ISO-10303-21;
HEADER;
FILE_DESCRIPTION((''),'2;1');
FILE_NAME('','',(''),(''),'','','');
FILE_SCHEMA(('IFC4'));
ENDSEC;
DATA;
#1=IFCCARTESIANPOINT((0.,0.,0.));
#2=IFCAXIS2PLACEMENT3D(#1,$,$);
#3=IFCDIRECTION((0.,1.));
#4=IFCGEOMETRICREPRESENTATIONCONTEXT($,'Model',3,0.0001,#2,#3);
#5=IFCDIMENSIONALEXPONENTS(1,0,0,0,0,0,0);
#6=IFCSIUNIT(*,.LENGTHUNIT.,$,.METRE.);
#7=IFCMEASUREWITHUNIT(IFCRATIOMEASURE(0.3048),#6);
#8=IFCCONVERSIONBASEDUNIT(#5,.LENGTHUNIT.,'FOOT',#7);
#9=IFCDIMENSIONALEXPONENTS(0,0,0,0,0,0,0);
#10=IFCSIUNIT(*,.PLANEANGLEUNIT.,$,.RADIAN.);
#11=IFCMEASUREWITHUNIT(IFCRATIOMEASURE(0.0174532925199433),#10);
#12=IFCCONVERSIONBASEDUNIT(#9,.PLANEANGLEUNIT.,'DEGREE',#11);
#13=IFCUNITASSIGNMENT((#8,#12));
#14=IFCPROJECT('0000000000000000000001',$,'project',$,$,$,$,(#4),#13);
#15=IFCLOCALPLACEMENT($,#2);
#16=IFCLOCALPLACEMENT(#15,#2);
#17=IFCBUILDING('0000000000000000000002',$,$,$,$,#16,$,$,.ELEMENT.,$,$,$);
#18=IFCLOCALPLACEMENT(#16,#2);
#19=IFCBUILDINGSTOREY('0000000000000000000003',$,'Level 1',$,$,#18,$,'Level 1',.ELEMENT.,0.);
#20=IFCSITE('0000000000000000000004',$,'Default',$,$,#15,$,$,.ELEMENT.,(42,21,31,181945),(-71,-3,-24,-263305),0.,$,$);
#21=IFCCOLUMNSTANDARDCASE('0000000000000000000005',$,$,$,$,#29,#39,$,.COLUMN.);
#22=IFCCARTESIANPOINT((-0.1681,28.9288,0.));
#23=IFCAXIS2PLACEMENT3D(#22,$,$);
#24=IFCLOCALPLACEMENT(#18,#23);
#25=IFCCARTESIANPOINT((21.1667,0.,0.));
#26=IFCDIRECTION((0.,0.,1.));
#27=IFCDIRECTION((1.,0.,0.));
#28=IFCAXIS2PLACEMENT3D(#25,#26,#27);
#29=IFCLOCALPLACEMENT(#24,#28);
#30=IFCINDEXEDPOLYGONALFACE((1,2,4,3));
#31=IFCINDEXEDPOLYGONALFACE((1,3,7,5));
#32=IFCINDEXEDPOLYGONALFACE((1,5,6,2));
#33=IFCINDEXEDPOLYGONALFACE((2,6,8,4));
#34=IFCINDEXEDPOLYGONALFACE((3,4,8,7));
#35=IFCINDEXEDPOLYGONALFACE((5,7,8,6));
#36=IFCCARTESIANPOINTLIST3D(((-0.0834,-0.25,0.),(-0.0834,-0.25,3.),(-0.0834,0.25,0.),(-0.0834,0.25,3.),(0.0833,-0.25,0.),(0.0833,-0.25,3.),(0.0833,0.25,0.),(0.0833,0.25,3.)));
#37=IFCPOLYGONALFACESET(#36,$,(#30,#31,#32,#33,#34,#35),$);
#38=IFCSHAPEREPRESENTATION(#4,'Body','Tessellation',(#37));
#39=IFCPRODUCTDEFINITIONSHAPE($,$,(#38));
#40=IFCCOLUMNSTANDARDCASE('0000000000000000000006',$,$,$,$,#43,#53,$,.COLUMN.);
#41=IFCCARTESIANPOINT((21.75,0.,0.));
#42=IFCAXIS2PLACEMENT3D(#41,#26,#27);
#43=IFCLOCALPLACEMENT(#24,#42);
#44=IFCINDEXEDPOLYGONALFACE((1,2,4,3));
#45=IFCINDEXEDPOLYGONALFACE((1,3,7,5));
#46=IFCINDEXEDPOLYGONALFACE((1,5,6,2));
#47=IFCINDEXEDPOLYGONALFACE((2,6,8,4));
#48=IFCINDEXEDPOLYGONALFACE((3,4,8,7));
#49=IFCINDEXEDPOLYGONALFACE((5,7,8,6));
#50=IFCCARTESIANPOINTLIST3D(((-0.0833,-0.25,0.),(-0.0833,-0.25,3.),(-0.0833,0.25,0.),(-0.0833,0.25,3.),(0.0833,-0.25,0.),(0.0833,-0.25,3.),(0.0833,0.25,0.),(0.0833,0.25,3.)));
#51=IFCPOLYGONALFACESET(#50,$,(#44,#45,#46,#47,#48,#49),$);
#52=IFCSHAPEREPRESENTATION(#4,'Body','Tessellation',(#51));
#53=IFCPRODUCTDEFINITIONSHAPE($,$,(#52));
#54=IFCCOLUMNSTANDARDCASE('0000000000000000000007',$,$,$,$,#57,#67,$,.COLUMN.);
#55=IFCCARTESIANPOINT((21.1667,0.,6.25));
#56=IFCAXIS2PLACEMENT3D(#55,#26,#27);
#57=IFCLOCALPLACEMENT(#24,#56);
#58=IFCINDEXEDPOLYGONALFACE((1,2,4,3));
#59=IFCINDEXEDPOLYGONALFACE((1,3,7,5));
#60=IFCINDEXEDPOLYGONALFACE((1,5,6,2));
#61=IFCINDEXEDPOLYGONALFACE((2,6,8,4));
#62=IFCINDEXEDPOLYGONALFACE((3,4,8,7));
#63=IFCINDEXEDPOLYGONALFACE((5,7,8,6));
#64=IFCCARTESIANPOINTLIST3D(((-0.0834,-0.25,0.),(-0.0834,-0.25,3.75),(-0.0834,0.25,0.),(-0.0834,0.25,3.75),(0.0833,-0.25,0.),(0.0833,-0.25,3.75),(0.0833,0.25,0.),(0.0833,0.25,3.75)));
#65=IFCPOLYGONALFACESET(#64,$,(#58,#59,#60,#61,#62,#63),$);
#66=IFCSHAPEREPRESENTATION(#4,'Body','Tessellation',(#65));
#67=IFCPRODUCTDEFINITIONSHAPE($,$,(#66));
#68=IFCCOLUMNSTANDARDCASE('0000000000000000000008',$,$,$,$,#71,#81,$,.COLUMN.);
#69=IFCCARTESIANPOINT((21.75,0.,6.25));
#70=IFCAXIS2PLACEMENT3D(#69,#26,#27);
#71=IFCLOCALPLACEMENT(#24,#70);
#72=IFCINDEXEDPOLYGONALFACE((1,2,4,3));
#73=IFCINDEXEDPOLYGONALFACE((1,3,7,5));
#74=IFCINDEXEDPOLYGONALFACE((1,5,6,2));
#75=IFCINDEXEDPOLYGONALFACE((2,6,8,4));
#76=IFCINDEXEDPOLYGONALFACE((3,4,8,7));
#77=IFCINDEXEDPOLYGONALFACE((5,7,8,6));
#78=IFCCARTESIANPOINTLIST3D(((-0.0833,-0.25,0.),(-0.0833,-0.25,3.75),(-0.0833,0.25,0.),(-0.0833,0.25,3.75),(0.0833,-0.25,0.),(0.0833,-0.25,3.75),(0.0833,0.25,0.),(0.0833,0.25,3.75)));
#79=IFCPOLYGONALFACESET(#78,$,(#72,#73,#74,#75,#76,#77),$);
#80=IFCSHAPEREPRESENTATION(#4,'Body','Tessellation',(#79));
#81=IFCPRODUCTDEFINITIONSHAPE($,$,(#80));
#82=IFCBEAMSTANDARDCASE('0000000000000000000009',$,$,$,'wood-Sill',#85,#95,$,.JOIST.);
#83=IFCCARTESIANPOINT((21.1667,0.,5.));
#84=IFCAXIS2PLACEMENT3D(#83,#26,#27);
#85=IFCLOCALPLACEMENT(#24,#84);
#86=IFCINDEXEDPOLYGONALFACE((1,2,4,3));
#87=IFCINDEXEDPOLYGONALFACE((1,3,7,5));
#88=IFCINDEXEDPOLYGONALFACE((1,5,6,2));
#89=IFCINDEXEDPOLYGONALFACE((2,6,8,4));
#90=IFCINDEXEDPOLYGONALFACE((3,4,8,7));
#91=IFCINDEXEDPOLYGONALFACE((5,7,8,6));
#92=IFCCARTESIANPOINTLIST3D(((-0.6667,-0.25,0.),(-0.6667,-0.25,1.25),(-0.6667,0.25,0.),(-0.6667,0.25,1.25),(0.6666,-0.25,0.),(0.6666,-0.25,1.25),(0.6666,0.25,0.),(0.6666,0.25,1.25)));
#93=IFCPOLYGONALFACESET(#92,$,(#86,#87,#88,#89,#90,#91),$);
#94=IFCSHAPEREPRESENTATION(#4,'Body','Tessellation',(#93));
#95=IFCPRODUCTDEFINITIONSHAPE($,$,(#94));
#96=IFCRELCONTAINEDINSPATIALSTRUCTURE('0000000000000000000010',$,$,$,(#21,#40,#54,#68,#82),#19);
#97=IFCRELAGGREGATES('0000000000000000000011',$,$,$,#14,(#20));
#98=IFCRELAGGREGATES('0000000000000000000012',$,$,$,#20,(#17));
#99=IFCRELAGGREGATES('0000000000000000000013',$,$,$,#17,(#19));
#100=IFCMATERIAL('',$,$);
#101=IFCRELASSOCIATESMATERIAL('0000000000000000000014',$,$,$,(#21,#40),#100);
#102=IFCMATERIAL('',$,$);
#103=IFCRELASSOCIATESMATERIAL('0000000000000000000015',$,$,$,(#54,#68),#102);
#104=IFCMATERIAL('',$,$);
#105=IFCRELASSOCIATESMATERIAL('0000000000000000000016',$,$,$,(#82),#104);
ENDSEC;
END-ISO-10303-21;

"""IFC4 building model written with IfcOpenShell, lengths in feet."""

from ifc_helpers import new_model, entity, si_unit, converted_unit, direction, frame, origin, place, context, project, spatial, rectangle, extrude, material, element, save


model = new_model("IFC4")

# Units and contexts
model_context = context("Model", 3, precision=0.0001, world=origin(), true_north=direction((0.0, 1.0)))
ifc_project = project(units=[converted_unit("LENGTHUNIT", "FOOT", entity("IfcRatioMeasure", 0.3048), si_unit("LENGTHUNIT", "METRE"), dimensions=[1, 0, 0, 0, 0, 0, 0]), converted_unit("PLANEANGLEUNIT", "DEGREE", entity("IfcRatioMeasure", 0.0174532925199433), si_unit("PLANEANGLEUNIT", "RADIAN"), dimensions=[0, 0, 0, 0, 0, 0, 0])], contexts=[model_context])

# Site, building, storey
site_placement = place(None, origin())
site = spatial("IfcSite", under=ifc_project, at=site_placement, Name="Default", CompositionType="ELEMENT", RefLatitude=(42, 21, 31, 181945), RefLongitude=(-71, -3, -24, -263305), RefElevation=0.0)
building_placement = place(site_placement, origin())
building = spatial("IfcBuilding", under=site, at=building_placement, CompositionType="ELEMENT")
storey_placement = place(building_placement, origin())
storey = spatial("IfcBuildingStorey", under=building, at=storey_placement, Name="Level 1", LongName="Level 1", CompositionType="ELEMENT", Elevation=0.0)

# Columns
ifc_material_1 = material(Name="")
placement = place(storey_placement, frame((-0.1681, 28.9288, 0.0)))
for number, where, z_axis, x_axis in (
    (1, (21.1667, 0.0, 0.0), (0.0, 0.0, 1.0), (1.0, 0.0, 0.0)),
    (2, (21.75, 0.0, 0.0), (0.0, 0.0, 1.0), (1.0, 0.0, 0.0)),
):
    element("IfcColumnStandardCase", number, at=place(placement, frame(where, z_axis=z_axis, x_axis=x_axis)), inside=storey, material=ifc_material_1, PredefinedType="COLUMN", context=model_context, shape_type="SweptSolid", body=[
        extrude(rectangle(XDim=0.1667, YDim=0.5), origin(), (0.0, 0.0, 1.0), 3.0),
    ])
ifc_material_2 = material(Name="")
for number, where, z_axis, x_axis in (
    (3, (21.1667, 0.0, 6.25), (0.0, 0.0, 1.0), (1.0, 0.0, 0.0)),
    (4, (21.75, 0.0, 6.25), (0.0, 0.0, 1.0), (1.0, 0.0, 0.0)),
):
    element("IfcColumnStandardCase", number, at=place(placement, frame(where, z_axis=z_axis, x_axis=x_axis)), inside=storey, material=ifc_material_2, PredefinedType="COLUMN", context=model_context, shape_type="SweptSolid", body=[
        extrude(rectangle(XDim=0.1667, YDim=0.5), origin(), (0.0, 0.0, 1.0), 3.75),
    ])

# Beam
ifc_material_3 = material(Name="")
for number, where, z_axis, x_axis in (
    (5, (21.1667, 0.0, 5.0), (0.0, 0.0, 1.0), (1.0, 0.0, 0.0)),
):
    element("IfcBeamStandardCase", number, at=place(placement, frame(where, z_axis=z_axis, x_axis=x_axis)), inside=storey, material=ifc_material_3, ObjectType="wood-Sill", PredefinedType="JOIST", context=model_context, shape_type="SweptSolid", body=[
        extrude(rectangle(XDim=1.3333, YDim=0.5), origin(), (0.0, 0.0, 1.0), 1.25),
    ])

save(model, "model.ifc")
